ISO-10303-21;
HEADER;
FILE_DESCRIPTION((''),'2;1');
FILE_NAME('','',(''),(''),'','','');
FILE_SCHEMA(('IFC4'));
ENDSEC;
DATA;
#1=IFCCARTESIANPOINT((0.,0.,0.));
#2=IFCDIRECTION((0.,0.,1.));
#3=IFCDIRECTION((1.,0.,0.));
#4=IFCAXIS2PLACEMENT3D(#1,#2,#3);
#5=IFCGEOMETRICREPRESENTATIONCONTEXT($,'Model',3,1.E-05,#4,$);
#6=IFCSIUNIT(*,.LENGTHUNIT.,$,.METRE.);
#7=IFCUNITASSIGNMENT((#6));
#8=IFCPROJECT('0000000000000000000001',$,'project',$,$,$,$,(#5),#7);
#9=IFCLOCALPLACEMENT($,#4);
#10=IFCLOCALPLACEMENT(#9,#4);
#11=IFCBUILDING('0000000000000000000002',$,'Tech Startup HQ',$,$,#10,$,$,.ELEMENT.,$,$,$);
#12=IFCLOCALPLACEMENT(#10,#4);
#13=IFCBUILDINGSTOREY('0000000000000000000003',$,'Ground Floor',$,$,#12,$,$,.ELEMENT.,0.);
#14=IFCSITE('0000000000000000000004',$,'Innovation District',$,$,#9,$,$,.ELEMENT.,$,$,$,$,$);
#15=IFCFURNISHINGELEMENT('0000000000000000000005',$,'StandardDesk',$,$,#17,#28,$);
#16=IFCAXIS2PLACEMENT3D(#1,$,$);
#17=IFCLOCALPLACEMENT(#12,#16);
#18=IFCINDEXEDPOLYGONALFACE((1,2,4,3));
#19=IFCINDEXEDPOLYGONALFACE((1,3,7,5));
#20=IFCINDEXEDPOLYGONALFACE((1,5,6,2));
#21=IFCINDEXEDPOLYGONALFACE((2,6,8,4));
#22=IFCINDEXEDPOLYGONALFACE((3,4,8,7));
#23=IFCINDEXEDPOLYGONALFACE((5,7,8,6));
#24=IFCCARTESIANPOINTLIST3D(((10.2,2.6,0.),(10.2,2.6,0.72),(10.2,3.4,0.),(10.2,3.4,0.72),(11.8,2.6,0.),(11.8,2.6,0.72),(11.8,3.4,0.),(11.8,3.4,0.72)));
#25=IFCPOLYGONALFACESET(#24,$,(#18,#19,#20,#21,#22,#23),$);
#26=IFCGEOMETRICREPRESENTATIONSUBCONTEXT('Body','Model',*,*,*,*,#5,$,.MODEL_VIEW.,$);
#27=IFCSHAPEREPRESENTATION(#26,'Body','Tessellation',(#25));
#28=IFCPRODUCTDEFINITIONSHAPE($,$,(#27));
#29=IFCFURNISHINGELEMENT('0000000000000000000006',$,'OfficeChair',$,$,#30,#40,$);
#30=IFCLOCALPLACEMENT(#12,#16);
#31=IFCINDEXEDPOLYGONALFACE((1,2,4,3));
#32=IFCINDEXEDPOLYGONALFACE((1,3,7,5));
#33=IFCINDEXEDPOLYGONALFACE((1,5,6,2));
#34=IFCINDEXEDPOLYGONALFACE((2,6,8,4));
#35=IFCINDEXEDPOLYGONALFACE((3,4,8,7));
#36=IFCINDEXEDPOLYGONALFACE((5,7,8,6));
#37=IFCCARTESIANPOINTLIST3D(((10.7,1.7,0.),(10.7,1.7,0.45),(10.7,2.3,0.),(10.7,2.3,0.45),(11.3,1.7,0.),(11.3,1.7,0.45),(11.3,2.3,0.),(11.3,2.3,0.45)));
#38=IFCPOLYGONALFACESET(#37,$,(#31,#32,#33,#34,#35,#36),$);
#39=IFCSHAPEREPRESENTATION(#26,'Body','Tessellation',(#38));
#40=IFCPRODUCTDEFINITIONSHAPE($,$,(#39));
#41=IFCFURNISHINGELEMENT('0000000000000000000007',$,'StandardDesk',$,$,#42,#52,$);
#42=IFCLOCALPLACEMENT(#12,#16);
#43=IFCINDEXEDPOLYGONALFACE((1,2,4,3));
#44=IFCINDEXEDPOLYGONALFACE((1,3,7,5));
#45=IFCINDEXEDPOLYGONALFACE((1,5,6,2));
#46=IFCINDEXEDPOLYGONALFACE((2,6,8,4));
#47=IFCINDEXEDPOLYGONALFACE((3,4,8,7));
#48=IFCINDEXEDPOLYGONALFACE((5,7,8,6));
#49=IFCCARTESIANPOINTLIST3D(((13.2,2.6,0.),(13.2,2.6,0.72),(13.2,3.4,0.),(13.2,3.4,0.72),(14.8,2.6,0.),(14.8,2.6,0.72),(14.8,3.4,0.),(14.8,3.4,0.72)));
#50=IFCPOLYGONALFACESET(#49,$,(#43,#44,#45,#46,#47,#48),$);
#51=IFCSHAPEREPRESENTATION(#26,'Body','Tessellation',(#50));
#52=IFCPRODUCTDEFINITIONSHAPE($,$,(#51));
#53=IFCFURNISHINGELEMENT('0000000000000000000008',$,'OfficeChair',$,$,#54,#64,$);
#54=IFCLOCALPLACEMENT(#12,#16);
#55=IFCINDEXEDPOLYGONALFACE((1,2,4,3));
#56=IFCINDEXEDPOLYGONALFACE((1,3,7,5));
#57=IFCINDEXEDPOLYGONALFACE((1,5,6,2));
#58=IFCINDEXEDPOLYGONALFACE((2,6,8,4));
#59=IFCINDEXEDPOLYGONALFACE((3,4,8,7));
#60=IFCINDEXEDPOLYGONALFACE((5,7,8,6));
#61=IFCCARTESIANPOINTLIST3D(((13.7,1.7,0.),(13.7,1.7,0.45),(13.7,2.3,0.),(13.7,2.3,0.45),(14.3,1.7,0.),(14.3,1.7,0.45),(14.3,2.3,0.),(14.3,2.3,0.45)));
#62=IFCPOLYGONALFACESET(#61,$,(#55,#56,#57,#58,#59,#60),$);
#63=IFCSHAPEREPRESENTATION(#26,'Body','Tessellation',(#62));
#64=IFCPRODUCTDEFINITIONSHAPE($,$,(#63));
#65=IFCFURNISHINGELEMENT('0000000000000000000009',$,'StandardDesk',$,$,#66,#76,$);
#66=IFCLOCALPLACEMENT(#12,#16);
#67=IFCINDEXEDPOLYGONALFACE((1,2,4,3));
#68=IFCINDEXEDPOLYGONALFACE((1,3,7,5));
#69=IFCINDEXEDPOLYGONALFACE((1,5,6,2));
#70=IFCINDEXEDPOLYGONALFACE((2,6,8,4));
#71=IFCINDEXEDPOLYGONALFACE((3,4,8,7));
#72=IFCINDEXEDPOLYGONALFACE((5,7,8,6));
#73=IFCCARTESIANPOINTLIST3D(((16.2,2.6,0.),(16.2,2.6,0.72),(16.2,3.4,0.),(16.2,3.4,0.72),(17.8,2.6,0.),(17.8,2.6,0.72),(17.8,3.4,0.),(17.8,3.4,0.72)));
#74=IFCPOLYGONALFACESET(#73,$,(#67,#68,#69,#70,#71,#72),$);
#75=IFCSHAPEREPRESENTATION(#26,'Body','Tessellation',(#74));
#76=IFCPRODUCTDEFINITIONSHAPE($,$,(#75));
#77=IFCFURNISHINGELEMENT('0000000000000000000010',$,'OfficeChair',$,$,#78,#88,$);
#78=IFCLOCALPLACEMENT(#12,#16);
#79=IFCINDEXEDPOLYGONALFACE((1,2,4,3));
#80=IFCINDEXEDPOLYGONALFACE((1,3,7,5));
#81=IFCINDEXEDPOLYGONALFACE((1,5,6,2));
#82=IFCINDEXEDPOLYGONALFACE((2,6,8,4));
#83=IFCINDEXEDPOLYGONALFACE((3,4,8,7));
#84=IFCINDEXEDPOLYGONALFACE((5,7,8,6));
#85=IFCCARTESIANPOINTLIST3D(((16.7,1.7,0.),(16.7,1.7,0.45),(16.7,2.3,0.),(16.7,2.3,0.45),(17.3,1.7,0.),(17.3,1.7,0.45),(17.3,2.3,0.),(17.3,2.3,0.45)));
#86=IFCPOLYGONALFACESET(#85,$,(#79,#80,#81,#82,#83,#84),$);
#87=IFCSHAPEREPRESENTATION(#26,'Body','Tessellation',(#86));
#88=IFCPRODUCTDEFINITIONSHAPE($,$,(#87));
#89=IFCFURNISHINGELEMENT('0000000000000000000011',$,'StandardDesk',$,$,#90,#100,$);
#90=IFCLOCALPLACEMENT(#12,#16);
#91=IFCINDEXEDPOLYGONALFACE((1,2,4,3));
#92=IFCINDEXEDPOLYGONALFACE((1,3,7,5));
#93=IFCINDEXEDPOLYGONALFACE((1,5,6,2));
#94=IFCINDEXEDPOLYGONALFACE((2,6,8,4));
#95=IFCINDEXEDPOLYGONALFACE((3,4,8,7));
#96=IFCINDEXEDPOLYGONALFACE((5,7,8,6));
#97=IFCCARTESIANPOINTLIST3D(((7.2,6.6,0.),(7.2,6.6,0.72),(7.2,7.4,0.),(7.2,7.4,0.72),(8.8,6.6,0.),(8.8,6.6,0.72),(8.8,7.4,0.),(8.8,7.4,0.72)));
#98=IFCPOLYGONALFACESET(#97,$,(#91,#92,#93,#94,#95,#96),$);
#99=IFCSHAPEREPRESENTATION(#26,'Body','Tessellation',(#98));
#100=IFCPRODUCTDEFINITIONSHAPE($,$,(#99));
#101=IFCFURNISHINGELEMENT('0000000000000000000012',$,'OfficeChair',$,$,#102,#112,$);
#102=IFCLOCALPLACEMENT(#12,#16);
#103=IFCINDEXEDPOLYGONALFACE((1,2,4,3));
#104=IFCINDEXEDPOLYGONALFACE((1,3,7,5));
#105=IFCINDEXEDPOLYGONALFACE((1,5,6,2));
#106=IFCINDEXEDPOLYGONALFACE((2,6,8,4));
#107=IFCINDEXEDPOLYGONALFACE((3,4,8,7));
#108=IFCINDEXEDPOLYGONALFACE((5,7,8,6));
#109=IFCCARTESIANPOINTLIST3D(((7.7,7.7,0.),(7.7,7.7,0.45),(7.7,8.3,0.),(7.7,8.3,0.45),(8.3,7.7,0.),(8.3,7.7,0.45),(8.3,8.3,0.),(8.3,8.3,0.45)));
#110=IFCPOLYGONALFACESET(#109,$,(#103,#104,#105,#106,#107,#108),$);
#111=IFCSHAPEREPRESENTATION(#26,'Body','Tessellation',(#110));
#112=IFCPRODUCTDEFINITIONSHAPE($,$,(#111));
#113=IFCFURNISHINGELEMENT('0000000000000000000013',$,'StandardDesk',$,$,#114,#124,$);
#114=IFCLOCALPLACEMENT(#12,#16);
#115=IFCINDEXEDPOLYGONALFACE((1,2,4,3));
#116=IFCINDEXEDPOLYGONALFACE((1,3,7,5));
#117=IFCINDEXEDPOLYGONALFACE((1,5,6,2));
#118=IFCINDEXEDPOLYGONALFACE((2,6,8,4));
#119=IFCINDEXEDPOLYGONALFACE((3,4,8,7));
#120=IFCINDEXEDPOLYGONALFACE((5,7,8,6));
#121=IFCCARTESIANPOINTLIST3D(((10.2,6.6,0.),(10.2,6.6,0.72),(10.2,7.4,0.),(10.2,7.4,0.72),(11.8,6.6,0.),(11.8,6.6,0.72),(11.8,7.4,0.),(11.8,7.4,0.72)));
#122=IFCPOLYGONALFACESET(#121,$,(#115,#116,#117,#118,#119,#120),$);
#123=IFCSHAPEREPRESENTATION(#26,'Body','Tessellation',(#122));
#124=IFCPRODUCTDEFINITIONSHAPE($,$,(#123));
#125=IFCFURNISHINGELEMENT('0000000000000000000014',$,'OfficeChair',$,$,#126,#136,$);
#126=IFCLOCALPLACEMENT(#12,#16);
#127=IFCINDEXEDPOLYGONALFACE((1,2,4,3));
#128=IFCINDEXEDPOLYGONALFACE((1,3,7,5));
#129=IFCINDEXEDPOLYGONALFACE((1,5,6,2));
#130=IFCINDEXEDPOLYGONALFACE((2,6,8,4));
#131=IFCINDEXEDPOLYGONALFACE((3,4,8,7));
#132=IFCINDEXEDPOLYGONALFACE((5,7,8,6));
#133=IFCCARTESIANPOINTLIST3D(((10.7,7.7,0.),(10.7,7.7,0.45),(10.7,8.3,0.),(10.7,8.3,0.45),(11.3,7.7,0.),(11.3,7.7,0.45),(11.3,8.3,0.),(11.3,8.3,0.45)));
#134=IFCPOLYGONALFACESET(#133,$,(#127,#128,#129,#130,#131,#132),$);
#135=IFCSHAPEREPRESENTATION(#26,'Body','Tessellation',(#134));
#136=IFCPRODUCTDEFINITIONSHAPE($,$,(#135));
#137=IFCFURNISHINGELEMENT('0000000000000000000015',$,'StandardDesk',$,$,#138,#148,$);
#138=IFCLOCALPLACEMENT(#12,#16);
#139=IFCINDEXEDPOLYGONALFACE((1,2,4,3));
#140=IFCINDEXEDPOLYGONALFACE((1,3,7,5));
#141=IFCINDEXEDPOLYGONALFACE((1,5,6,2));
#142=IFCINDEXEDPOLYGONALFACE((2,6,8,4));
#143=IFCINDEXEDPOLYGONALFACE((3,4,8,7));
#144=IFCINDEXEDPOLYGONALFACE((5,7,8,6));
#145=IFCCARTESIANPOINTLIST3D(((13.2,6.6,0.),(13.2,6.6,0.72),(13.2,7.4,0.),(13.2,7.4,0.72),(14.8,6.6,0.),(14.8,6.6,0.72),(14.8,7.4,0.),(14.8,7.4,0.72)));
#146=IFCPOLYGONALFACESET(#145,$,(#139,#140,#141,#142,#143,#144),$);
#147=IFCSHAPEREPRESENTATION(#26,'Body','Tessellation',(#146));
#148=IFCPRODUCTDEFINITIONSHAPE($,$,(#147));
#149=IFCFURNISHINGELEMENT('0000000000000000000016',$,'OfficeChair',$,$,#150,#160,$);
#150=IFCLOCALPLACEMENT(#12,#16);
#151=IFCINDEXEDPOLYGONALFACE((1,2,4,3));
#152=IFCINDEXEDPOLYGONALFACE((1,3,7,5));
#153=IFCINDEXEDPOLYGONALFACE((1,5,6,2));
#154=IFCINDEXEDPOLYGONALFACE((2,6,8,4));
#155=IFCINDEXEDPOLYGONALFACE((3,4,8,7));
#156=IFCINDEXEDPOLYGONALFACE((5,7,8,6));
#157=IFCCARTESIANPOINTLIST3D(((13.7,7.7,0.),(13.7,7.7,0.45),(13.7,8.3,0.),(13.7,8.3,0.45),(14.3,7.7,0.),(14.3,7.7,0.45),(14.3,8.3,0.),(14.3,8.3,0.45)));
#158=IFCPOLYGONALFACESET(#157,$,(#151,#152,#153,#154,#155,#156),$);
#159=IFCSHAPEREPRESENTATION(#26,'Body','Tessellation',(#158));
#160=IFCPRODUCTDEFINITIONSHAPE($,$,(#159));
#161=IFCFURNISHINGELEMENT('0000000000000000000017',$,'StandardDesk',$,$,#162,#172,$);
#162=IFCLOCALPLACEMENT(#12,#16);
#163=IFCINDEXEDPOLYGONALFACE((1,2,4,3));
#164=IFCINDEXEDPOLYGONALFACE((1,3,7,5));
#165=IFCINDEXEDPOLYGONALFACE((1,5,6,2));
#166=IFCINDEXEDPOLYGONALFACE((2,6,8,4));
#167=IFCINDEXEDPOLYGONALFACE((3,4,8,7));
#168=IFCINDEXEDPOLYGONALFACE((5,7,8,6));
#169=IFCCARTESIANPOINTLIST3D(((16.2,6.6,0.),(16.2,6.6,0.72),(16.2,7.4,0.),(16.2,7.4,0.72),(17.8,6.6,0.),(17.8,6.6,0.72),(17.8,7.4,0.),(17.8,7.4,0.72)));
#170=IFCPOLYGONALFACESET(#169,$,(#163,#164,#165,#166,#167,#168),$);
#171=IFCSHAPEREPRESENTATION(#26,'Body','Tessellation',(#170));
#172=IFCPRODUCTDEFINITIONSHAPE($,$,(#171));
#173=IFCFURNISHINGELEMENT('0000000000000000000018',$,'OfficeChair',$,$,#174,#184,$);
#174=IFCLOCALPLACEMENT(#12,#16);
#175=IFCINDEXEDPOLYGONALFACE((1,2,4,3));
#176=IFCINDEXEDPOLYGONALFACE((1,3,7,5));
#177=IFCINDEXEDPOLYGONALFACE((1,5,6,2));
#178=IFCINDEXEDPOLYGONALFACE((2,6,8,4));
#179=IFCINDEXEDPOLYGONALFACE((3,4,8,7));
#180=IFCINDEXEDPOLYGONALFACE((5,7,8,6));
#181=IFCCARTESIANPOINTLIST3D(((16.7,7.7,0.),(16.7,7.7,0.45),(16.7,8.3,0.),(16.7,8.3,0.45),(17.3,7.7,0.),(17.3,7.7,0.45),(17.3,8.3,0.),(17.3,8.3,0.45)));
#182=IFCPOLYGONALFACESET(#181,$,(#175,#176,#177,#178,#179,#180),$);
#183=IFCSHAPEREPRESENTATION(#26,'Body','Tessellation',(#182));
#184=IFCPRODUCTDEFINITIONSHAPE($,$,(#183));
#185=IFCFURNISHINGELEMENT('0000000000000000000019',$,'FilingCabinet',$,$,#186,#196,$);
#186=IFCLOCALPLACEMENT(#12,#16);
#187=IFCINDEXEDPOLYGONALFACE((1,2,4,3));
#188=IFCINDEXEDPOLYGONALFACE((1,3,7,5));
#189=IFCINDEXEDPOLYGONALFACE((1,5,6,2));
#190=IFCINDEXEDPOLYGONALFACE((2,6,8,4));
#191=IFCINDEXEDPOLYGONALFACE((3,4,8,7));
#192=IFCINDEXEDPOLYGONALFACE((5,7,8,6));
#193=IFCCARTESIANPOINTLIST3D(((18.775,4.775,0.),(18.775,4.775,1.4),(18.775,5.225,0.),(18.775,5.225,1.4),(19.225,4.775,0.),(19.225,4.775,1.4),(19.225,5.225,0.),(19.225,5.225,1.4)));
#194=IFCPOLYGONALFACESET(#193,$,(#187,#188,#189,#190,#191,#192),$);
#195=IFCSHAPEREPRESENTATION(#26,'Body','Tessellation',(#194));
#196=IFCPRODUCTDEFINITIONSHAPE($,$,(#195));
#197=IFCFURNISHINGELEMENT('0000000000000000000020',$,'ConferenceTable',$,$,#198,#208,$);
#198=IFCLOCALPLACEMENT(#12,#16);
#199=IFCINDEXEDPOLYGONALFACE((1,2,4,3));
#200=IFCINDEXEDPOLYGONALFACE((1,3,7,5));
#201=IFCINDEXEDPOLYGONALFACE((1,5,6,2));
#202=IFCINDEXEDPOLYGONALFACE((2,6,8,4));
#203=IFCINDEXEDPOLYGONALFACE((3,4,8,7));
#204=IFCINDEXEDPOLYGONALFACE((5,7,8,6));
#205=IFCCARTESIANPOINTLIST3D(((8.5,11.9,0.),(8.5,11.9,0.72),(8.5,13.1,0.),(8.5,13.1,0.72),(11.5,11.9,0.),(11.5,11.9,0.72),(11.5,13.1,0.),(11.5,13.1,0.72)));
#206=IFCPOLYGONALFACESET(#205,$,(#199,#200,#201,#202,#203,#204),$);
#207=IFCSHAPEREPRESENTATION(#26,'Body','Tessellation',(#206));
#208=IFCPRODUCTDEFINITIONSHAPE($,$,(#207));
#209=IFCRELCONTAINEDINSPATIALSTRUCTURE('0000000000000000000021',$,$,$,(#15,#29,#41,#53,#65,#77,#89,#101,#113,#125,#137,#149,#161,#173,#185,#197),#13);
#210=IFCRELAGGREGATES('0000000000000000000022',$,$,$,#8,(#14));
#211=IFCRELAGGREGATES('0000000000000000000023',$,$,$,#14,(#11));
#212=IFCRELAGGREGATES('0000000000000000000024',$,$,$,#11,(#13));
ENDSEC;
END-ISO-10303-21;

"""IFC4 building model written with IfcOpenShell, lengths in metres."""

from ifc_helpers import new_model, si_unit, origin_with_axes, place, context, subcontext, project, spatial, polyline, outline, extrude, element, save


model = new_model("IFC4")

# Units and contexts
model_context = context("Model", 3, precision=1e-05, world=origin_with_axes())
body_context = subcontext(model_context, "Body", "Model", "MODEL_VIEW")
ifc_project = project(units=[si_unit("LENGTHUNIT", "METRE")], contexts=[model_context])

# Site, building, storey
site_placement = place(None, origin_with_axes())
site = spatial("IfcSite", under=ifc_project, at=site_placement, Name="Innovation District", CompositionType="ELEMENT")
building_placement = place(site_placement, origin_with_axes())
building = spatial("IfcBuilding", under=site, at=building_placement, Name="Tech Startup HQ", CompositionType="ELEMENT")
storey_placement = place(building_placement, origin_with_axes())
storey = spatial("IfcBuildingStorey", under=building, at=storey_placement, Name="Ground Floor", CompositionType="ELEMENT", Elevation=0.0)

# Furnishing elements
furnishing_1_placement = place(storey_placement, origin_with_axes())
element("IfcFurnishingElement", 1, at=furnishing_1_placement, inside=storey, Name="StandardDesk", context=body_context, shape_type="SweptSolid", body=[
    extrude(outline(polyline([(10.2, 2.6, 0.0), (11.8, 2.6, 0.0), (11.8, 3.4, 0.0), (10.2, 3.4, 0.0), (10.2, 2.6, 0.0)])), None, (0.0, 0.0, 1.0), 0.72),
])
furnishing_2_placement = place(storey_placement, origin_with_axes())
element("IfcFurnishingElement", 2, at=furnishing_2_placement, inside=storey, Name="OfficeChair", context=body_context, shape_type="SweptSolid", body=[
    extrude(outline(polyline([(10.7, 1.7, 0.0), (11.3, 1.7, 0.0), (11.3, 2.3, 0.0), (10.7, 2.3, 0.0), (10.7, 1.7, 0.0)])), None, (0.0, 0.0, 1.0), 0.45),
])
furnishing_3_placement = place(storey_placement, origin_with_axes())
element("IfcFurnishingElement", 3, at=furnishing_3_placement, inside=storey, Name="StandardDesk", context=body_context, shape_type="SweptSolid", body=[
    extrude(outline(polyline([(13.2, 2.6, 0.0), (14.8, 2.6, 0.0), (14.8, 3.4, 0.0), (13.2, 3.4, 0.0), (13.2, 2.6, 0.0)])), None, (0.0, 0.0, 1.0), 0.72),
])
furnishing_4_placement = place(storey_placement, origin_with_axes())
element("IfcFurnishingElement", 4, at=furnishing_4_placement, inside=storey, Name="OfficeChair", context=body_context, shape_type="SweptSolid", body=[
    extrude(outline(polyline([(13.7, 1.7, 0.0), (14.3, 1.7, 0.0), (14.3, 2.3, 0.0), (13.7, 2.3, 0.0), (13.7, 1.7, 0.0)])), None, (0.0, 0.0, 1.0), 0.45),
])
furnishing_5_placement = place(storey_placement, origin_with_axes())
element("IfcFurnishingElement", 5, at=furnishing_5_placement, inside=storey, Name="StandardDesk", context=body_context, shape_type="SweptSolid", body=[
    extrude(outline(polyline([(16.2, 2.6, 0.0), (17.8, 2.6, 0.0), (17.8, 3.4, 0.0), (16.2, 3.4, 0.0), (16.2, 2.6, 0.0)])), None, (0.0, 0.0, 1.0), 0.72),
])
furnishing_6_placement = place(storey_placement, origin_with_axes())
element("IfcFurnishingElement", 6, at=furnishing_6_placement, inside=storey, Name="OfficeChair", context=body_context, shape_type="SweptSolid", body=[
    extrude(outline(polyline([(16.7, 1.7, 0.0), (17.3, 1.7, 0.0), (17.3, 2.3, 0.0), (16.7, 2.3, 0.0), (16.7, 1.7, 0.0)])), None, (0.0, 0.0, 1.0), 0.45),
])
furnishing_7_placement = place(storey_placement, origin_with_axes())
element("IfcFurnishingElement", 7, at=furnishing_7_placement, inside=storey, Name="StandardDesk", context=body_context, shape_type="SweptSolid", body=[
    extrude(outline(polyline([(7.2, 6.6, 0.0), (8.8, 6.6, 0.0), (8.8, 7.4, 0.0), (7.2, 7.4, 0.0), (7.2, 6.6, 0.0)])), None, (0.0, 0.0, 1.0), 0.72),
])
furnishing_8_placement = place(storey_placement, origin_with_axes())
element("IfcFurnishingElement", 8, at=furnishing_8_placement, inside=storey, Name="OfficeChair", context=body_context, shape_type="SweptSolid", body=[
    extrude(outline(polyline([(8.3, 8.3, 0.0), (7.7, 8.3, 0.0), (7.7, 7.7, 0.0), (8.3, 7.7, 0.0), (8.3, 8.3, 0.0)])), None, (0.0, 0.0, 1.0), 0.45),
])
furnishing_9_placement = place(storey_placement, origin_with_axes())
element("IfcFurnishingElement", 9, at=furnishing_9_placement, inside=storey, Name="StandardDesk", context=body_context, shape_type="SweptSolid", body=[
    extrude(outline(polyline([(10.2, 6.6, 0.0), (11.8, 6.6, 0.0), (11.8, 7.4, 0.0), (10.2, 7.4, 0.0), (10.2, 6.6, 0.0)])), None, (0.0, 0.0, 1.0), 0.72),
])
furnishing_10_placement = place(storey_placement, origin_with_axes())
element("IfcFurnishingElement", 10, at=furnishing_10_placement, inside=storey, Name="OfficeChair", context=body_context, shape_type="SweptSolid", body=[
    extrude(outline(polyline([(11.3, 8.3, 0.0), (10.7, 8.3, 0.0), (10.7, 7.7, 0.0), (11.3, 7.7, 0.0), (11.3, 8.3, 0.0)])), None, (0.0, 0.0, 1.0), 0.45),
])
furnishing_11_placement = place(storey_placement, origin_with_axes())
element("IfcFurnishingElement", 11, at=furnishing_11_placement, inside=storey, Name="StandardDesk", context=body_context, shape_type="SweptSolid", body=[
    extrude(outline(polyline([(13.2, 6.6, 0.0), (14.8, 6.6, 0.0), (14.8, 7.4, 0.0), (13.2, 7.4, 0.0), (13.2, 6.6, 0.0)])), None, (0.0, 0.0, 1.0), 0.72),
])
furnishing_12_placement = place(storey_placement, origin_with_axes())
element("IfcFurnishingElement", 12, at=furnishing_12_placement, inside=storey, Name="OfficeChair", context=body_context, shape_type="SweptSolid", body=[
    extrude(outline(polyline([(14.3, 8.3, 0.0), (13.7, 8.3, 0.0), (13.7, 7.7, 0.0), (14.3, 7.7, 0.0), (14.3, 8.3, 0.0)])), None, (0.0, 0.0, 1.0), 0.45),
])
furnishing_13_placement = place(storey_placement, origin_with_axes())
element("IfcFurnishingElement", 13, at=furnishing_13_placement, inside=storey, Name="StandardDesk", context=body_context, shape_type="SweptSolid", body=[
    extrude(outline(polyline([(16.2, 6.6, 0.0), (17.8, 6.6, 0.0), (17.8, 7.4, 0.0), (16.2, 7.4, 0.0), (16.2, 6.6, 0.0)])), None, (0.0, 0.0, 1.0), 0.72),
])
furnishing_14_placement = place(storey_placement, origin_with_axes())
element("IfcFurnishingElement", 14, at=furnishing_14_placement, inside=storey, Name="OfficeChair", context=body_context, shape_type="SweptSolid", body=[
    extrude(outline(polyline([(17.3, 8.3, 0.0), (16.7, 8.3, 0.0), (16.7, 7.7, 0.0), (17.3, 7.7, 0.0), (17.3, 8.3, 0.0)])), None, (0.0, 0.0, 1.0), 0.45),
])
furnishing_15_placement = place(storey_placement, origin_with_axes())
element("IfcFurnishingElement", 15, at=furnishing_15_placement, inside=storey, Name="FilingCabinet", context=body_context, shape_type="SweptSolid", body=[
    extrude(outline(polyline([(18.775, 4.775, 0.0), (19.225, 4.775, 0.0), (19.225, 5.225, 0.0), (18.775, 5.225, 0.0), (18.775, 4.775, 0.0)])), None, (0.0, 0.0, 1.0), 1.4),
])
furnishing_16_placement = place(storey_placement, origin_with_axes())
element("IfcFurnishingElement", 16, at=furnishing_16_placement, inside=storey, Name="ConferenceTable", context=body_context, shape_type="SweptSolid", body=[
    extrude(outline(polyline([(8.5, 11.9, 0.0), (11.5, 11.9, 0.0), (11.5, 13.1, 0.0), (8.5, 13.1, 0.0), (8.5, 11.9, 0.0)])), None, (0.0, 0.0, 1.0), 0.72),
])

save(model, "model.ifc")
